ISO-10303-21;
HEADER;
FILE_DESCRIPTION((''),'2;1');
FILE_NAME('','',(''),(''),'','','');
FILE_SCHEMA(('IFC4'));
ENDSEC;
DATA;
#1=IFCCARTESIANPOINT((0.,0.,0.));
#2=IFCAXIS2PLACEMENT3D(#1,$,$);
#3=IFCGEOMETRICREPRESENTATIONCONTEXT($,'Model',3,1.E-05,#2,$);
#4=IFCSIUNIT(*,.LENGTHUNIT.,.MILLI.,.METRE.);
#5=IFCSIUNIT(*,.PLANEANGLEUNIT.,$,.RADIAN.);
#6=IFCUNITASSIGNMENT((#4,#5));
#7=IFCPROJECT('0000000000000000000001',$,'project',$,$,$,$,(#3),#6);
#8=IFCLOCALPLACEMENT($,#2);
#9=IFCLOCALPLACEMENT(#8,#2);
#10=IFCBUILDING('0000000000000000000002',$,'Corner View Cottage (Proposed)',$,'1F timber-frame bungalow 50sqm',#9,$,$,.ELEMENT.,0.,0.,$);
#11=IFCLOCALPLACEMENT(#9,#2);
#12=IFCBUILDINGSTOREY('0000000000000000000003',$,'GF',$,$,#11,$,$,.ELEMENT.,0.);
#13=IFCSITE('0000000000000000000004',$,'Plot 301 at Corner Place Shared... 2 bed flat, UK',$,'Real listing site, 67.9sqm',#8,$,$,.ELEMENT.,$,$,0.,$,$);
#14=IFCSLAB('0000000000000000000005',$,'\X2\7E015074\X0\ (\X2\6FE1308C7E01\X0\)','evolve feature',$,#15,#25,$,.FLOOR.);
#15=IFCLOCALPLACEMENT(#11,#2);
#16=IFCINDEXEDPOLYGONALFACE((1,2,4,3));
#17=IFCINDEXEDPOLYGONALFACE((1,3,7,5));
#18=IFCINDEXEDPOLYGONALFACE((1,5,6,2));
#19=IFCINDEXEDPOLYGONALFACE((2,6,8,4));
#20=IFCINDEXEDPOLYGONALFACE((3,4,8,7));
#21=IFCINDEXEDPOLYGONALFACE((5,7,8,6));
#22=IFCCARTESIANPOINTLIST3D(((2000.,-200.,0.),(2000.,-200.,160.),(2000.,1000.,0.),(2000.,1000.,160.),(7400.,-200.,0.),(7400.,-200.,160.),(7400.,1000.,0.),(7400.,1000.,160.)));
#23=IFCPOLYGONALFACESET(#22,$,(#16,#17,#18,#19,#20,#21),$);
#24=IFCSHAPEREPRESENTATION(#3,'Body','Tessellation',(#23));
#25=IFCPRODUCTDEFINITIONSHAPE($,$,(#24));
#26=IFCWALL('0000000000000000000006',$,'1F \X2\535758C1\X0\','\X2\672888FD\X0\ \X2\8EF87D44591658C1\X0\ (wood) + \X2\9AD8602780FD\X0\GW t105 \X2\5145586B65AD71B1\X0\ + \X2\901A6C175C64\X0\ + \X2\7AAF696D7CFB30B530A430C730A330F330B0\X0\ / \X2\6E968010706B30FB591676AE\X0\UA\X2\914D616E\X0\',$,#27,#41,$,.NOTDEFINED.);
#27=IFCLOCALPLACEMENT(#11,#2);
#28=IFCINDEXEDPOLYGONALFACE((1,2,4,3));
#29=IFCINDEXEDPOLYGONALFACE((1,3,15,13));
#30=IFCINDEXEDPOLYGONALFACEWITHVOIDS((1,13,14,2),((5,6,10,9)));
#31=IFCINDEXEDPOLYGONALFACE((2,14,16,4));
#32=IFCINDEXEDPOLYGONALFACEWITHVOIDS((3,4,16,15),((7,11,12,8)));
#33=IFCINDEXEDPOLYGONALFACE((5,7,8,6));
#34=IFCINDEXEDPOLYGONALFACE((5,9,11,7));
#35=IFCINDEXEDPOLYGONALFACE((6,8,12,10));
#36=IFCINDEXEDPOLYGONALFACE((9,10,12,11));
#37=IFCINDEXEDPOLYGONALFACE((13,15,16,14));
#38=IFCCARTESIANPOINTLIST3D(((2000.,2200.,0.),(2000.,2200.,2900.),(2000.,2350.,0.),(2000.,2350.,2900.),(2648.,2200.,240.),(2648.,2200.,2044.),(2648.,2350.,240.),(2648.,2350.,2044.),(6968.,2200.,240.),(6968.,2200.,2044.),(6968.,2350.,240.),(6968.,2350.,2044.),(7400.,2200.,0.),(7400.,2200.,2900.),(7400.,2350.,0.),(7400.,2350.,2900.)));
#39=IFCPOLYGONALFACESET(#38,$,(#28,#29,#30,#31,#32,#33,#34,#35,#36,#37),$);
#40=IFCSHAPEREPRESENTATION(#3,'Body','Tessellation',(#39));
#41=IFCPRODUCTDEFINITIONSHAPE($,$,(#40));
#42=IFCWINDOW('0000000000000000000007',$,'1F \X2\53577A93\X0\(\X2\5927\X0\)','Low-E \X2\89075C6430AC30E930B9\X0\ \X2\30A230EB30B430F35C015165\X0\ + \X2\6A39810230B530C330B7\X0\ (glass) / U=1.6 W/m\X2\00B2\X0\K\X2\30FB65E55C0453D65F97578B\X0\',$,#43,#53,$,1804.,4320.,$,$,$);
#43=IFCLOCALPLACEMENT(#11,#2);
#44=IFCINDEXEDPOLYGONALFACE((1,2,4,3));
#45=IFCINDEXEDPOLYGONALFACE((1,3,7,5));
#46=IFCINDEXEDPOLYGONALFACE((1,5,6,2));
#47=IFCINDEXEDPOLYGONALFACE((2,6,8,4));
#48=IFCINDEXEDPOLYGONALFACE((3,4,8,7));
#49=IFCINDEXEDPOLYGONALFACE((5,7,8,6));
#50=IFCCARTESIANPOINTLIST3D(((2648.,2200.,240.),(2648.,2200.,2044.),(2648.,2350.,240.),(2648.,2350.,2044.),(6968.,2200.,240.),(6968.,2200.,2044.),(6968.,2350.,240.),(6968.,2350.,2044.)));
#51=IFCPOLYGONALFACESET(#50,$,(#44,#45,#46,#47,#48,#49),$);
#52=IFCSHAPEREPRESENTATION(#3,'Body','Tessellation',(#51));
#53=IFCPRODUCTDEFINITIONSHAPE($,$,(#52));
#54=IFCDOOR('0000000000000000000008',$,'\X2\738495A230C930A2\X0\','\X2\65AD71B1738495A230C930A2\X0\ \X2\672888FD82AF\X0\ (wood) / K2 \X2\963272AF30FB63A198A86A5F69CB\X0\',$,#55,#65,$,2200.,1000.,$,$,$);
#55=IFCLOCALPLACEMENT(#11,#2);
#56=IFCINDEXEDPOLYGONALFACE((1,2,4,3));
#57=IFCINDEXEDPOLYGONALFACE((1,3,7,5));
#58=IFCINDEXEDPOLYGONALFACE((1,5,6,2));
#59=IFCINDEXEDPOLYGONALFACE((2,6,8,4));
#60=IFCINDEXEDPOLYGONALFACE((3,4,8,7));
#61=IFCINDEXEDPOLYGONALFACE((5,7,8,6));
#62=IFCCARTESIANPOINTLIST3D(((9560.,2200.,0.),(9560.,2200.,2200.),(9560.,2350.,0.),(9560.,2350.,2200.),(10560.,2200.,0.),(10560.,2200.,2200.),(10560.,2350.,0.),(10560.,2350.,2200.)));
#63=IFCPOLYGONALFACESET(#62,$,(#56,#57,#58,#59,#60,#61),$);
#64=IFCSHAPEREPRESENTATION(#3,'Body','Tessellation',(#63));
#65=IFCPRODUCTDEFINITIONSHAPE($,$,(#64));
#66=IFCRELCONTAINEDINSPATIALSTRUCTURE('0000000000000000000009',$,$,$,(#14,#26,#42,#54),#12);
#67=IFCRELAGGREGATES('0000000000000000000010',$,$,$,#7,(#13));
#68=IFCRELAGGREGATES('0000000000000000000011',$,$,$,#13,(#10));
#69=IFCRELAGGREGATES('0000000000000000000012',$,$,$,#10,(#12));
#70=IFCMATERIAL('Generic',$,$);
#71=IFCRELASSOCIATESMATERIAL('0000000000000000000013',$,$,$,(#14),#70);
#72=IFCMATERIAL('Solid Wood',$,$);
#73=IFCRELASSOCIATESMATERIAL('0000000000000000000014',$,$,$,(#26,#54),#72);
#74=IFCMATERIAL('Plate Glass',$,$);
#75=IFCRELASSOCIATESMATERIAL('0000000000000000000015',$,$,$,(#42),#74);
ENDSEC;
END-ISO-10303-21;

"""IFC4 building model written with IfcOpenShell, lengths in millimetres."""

from ifc_helpers import new_model, si_unit, frame, frame_2d, origin, place, context, project, spatial, rectangle, extrude, material, element, fill, save


model = new_model("IFC4")

# Units and contexts
model_context = context("Model", 3, precision=1e-05, world=origin())
ifc_project = project(units=[si_unit("LENGTHUNIT", "METRE", prefix="MILLI"), si_unit("PLANEANGLEUNIT", "RADIAN")], contexts=[model_context])

# Site, building, storey
site_placement = place(None, origin())
site = spatial("IfcSite", under=ifc_project, at=site_placement, Name="Plot 301 at Corner Place Shared... 2 bed flat, UK", ObjectType="Real listing site, 67.9sqm", CompositionType="ELEMENT", RefElevation=0.0)
building_placement = place(site_placement, origin())
building = spatial("IfcBuilding", under=site, at=building_placement, Name="Corner View Cottage (Proposed)", ObjectType="1F timber-frame bungalow 50sqm", CompositionType="ELEMENT", ElevationOfRefHeight=0.0, ElevationOfTerrain=0.0)
storey_placement = place(building_placement, origin())
storey = spatial("IfcBuildingStorey", under=building, at=storey_placement, Name="GF", CompositionType="ELEMENT", Elevation=0.0)

# Slab
ifc_material_1 = material(Name="Solid Wood")
ifc_material_2 = material(Name="Generic")
slab_1_placement = place(storey_placement, frame((1000.0, -100.0, 0.0)))
element("IfcSlab", 1, at=slab_1_placement, inside=storey, material=ifc_material_2, Name="縁側 (濡れ縁)", Description="evolve feature", PredefinedType="FLOOR", context=model_context, shape_type="SweptSolid", body=[
    extrude(rectangle(XDim=5400.0, YDim=1200.0, at=frame_2d((2700.0, 600.0))), frame((1000.0, -100.0, 0.0)), (0.0, 0.0, 1.0), 160.0),
])

# Wall, openings, window, door
wall_1_placement = place(storey_placement, frame((1000.0, 1100.0, 0.0)))
wall_1 = element("IfcWall", 2, at=wall_1_placement, inside=storey, material=ifc_material_1, Name="1F 南壁", Description="木製 軸組外壁 (wood) + 高性能GW t105 充填断熱 + 通気層 + 窯業系サイディング / 準耐火・外皮UA配慮", PredefinedType="NOTDEFINED", context=model_context, shape_type="SweptSolid", body=[
    extrude(rectangle(XDim=5400.0, YDim=150.0, at=frame_2d((2700.0, 75.0))), frame((1000.0, 1100.0, 0.0)), (0.0, 0.0, 1.0), 2900.0),
])
opening_1_placement = place(storey_placement, frame((1324.0, 1100.0, 120.0)))
opening_1 = element("IfcOpeningElement", 3, at=opening_1_placement, cuts=wall_1, PredefinedType="NOTDEFINED", context=model_context, shape_type="SweptSolid", body=[
    extrude(rectangle(XDim=4320.0, YDim=150.0, at=frame_2d((2160.0, 75.0))), frame((1324.0, 1100.0, 120.0)), (0.0, 0.0, 1.0), 1804.0),
])
opening_2_placement = place(storey_placement, frame((4780.0, 1100.0, 0.0)))
opening_2 = element("IfcOpeningElement", 4, at=opening_2_placement, cuts=wall_1, PredefinedType="NOTDEFINED", context=model_context, shape_type="SweptSolid", body=[
    extrude(rectangle(XDim=1000.0, YDim=150.0, at=frame_2d((500.0, 75.0))), frame((4780.0, 1100.0, 0.0)), (0.0, 0.0, 1.0), 2200.0),
])
ifc_material_3 = material(Name="Plate Glass")
window_1_placement = place(storey_placement, frame((1324.0, 1100.0, 120.0)))
window_1 = element("IfcWindow", 5, at=window_1_placement, inside=storey, material=ifc_material_3, Name="1F 南窓(大)", Description="Low-E 複層ガラス アルゴン封入 + 樹脂サッシ (glass) / U=1.6 W/m²K・日射取得型", OverallHeight=1804.0, OverallWidth=4320.0, context=model_context, shape_type="SweptSolid", body=[
    extrude(rectangle(XDim=4320.0, YDim=150.0, at=frame_2d((2160.0, 75.0))), frame((1324.0, 1100.0, 120.0)), (0.0, 0.0, 1.0), 1804.0),
])
fill(opening_1, window_1)
door_placement = place(storey_placement, frame((4780.0, 1100.0, 0.0)))
door = element("IfcDoor", 6, at=door_placement, inside=storey, material=ifc_material_1, Name="玄関ドア", Description="断熱玄関ドア 木製芯 (wood) / K2 防犯・採風機構", OverallHeight=2200.0, OverallWidth=1000.0, context=model_context, shape_type="SweptSolid", body=[
    extrude(rectangle(XDim=1000.0, YDim=150.0, at=frame_2d((500.0, 75.0))), frame((4780.0, 1100.0, 0.0)), (0.0, 0.0, 1.0), 2200.0),
])
fill(opening_2, door)

save(model, "model.ifc")
